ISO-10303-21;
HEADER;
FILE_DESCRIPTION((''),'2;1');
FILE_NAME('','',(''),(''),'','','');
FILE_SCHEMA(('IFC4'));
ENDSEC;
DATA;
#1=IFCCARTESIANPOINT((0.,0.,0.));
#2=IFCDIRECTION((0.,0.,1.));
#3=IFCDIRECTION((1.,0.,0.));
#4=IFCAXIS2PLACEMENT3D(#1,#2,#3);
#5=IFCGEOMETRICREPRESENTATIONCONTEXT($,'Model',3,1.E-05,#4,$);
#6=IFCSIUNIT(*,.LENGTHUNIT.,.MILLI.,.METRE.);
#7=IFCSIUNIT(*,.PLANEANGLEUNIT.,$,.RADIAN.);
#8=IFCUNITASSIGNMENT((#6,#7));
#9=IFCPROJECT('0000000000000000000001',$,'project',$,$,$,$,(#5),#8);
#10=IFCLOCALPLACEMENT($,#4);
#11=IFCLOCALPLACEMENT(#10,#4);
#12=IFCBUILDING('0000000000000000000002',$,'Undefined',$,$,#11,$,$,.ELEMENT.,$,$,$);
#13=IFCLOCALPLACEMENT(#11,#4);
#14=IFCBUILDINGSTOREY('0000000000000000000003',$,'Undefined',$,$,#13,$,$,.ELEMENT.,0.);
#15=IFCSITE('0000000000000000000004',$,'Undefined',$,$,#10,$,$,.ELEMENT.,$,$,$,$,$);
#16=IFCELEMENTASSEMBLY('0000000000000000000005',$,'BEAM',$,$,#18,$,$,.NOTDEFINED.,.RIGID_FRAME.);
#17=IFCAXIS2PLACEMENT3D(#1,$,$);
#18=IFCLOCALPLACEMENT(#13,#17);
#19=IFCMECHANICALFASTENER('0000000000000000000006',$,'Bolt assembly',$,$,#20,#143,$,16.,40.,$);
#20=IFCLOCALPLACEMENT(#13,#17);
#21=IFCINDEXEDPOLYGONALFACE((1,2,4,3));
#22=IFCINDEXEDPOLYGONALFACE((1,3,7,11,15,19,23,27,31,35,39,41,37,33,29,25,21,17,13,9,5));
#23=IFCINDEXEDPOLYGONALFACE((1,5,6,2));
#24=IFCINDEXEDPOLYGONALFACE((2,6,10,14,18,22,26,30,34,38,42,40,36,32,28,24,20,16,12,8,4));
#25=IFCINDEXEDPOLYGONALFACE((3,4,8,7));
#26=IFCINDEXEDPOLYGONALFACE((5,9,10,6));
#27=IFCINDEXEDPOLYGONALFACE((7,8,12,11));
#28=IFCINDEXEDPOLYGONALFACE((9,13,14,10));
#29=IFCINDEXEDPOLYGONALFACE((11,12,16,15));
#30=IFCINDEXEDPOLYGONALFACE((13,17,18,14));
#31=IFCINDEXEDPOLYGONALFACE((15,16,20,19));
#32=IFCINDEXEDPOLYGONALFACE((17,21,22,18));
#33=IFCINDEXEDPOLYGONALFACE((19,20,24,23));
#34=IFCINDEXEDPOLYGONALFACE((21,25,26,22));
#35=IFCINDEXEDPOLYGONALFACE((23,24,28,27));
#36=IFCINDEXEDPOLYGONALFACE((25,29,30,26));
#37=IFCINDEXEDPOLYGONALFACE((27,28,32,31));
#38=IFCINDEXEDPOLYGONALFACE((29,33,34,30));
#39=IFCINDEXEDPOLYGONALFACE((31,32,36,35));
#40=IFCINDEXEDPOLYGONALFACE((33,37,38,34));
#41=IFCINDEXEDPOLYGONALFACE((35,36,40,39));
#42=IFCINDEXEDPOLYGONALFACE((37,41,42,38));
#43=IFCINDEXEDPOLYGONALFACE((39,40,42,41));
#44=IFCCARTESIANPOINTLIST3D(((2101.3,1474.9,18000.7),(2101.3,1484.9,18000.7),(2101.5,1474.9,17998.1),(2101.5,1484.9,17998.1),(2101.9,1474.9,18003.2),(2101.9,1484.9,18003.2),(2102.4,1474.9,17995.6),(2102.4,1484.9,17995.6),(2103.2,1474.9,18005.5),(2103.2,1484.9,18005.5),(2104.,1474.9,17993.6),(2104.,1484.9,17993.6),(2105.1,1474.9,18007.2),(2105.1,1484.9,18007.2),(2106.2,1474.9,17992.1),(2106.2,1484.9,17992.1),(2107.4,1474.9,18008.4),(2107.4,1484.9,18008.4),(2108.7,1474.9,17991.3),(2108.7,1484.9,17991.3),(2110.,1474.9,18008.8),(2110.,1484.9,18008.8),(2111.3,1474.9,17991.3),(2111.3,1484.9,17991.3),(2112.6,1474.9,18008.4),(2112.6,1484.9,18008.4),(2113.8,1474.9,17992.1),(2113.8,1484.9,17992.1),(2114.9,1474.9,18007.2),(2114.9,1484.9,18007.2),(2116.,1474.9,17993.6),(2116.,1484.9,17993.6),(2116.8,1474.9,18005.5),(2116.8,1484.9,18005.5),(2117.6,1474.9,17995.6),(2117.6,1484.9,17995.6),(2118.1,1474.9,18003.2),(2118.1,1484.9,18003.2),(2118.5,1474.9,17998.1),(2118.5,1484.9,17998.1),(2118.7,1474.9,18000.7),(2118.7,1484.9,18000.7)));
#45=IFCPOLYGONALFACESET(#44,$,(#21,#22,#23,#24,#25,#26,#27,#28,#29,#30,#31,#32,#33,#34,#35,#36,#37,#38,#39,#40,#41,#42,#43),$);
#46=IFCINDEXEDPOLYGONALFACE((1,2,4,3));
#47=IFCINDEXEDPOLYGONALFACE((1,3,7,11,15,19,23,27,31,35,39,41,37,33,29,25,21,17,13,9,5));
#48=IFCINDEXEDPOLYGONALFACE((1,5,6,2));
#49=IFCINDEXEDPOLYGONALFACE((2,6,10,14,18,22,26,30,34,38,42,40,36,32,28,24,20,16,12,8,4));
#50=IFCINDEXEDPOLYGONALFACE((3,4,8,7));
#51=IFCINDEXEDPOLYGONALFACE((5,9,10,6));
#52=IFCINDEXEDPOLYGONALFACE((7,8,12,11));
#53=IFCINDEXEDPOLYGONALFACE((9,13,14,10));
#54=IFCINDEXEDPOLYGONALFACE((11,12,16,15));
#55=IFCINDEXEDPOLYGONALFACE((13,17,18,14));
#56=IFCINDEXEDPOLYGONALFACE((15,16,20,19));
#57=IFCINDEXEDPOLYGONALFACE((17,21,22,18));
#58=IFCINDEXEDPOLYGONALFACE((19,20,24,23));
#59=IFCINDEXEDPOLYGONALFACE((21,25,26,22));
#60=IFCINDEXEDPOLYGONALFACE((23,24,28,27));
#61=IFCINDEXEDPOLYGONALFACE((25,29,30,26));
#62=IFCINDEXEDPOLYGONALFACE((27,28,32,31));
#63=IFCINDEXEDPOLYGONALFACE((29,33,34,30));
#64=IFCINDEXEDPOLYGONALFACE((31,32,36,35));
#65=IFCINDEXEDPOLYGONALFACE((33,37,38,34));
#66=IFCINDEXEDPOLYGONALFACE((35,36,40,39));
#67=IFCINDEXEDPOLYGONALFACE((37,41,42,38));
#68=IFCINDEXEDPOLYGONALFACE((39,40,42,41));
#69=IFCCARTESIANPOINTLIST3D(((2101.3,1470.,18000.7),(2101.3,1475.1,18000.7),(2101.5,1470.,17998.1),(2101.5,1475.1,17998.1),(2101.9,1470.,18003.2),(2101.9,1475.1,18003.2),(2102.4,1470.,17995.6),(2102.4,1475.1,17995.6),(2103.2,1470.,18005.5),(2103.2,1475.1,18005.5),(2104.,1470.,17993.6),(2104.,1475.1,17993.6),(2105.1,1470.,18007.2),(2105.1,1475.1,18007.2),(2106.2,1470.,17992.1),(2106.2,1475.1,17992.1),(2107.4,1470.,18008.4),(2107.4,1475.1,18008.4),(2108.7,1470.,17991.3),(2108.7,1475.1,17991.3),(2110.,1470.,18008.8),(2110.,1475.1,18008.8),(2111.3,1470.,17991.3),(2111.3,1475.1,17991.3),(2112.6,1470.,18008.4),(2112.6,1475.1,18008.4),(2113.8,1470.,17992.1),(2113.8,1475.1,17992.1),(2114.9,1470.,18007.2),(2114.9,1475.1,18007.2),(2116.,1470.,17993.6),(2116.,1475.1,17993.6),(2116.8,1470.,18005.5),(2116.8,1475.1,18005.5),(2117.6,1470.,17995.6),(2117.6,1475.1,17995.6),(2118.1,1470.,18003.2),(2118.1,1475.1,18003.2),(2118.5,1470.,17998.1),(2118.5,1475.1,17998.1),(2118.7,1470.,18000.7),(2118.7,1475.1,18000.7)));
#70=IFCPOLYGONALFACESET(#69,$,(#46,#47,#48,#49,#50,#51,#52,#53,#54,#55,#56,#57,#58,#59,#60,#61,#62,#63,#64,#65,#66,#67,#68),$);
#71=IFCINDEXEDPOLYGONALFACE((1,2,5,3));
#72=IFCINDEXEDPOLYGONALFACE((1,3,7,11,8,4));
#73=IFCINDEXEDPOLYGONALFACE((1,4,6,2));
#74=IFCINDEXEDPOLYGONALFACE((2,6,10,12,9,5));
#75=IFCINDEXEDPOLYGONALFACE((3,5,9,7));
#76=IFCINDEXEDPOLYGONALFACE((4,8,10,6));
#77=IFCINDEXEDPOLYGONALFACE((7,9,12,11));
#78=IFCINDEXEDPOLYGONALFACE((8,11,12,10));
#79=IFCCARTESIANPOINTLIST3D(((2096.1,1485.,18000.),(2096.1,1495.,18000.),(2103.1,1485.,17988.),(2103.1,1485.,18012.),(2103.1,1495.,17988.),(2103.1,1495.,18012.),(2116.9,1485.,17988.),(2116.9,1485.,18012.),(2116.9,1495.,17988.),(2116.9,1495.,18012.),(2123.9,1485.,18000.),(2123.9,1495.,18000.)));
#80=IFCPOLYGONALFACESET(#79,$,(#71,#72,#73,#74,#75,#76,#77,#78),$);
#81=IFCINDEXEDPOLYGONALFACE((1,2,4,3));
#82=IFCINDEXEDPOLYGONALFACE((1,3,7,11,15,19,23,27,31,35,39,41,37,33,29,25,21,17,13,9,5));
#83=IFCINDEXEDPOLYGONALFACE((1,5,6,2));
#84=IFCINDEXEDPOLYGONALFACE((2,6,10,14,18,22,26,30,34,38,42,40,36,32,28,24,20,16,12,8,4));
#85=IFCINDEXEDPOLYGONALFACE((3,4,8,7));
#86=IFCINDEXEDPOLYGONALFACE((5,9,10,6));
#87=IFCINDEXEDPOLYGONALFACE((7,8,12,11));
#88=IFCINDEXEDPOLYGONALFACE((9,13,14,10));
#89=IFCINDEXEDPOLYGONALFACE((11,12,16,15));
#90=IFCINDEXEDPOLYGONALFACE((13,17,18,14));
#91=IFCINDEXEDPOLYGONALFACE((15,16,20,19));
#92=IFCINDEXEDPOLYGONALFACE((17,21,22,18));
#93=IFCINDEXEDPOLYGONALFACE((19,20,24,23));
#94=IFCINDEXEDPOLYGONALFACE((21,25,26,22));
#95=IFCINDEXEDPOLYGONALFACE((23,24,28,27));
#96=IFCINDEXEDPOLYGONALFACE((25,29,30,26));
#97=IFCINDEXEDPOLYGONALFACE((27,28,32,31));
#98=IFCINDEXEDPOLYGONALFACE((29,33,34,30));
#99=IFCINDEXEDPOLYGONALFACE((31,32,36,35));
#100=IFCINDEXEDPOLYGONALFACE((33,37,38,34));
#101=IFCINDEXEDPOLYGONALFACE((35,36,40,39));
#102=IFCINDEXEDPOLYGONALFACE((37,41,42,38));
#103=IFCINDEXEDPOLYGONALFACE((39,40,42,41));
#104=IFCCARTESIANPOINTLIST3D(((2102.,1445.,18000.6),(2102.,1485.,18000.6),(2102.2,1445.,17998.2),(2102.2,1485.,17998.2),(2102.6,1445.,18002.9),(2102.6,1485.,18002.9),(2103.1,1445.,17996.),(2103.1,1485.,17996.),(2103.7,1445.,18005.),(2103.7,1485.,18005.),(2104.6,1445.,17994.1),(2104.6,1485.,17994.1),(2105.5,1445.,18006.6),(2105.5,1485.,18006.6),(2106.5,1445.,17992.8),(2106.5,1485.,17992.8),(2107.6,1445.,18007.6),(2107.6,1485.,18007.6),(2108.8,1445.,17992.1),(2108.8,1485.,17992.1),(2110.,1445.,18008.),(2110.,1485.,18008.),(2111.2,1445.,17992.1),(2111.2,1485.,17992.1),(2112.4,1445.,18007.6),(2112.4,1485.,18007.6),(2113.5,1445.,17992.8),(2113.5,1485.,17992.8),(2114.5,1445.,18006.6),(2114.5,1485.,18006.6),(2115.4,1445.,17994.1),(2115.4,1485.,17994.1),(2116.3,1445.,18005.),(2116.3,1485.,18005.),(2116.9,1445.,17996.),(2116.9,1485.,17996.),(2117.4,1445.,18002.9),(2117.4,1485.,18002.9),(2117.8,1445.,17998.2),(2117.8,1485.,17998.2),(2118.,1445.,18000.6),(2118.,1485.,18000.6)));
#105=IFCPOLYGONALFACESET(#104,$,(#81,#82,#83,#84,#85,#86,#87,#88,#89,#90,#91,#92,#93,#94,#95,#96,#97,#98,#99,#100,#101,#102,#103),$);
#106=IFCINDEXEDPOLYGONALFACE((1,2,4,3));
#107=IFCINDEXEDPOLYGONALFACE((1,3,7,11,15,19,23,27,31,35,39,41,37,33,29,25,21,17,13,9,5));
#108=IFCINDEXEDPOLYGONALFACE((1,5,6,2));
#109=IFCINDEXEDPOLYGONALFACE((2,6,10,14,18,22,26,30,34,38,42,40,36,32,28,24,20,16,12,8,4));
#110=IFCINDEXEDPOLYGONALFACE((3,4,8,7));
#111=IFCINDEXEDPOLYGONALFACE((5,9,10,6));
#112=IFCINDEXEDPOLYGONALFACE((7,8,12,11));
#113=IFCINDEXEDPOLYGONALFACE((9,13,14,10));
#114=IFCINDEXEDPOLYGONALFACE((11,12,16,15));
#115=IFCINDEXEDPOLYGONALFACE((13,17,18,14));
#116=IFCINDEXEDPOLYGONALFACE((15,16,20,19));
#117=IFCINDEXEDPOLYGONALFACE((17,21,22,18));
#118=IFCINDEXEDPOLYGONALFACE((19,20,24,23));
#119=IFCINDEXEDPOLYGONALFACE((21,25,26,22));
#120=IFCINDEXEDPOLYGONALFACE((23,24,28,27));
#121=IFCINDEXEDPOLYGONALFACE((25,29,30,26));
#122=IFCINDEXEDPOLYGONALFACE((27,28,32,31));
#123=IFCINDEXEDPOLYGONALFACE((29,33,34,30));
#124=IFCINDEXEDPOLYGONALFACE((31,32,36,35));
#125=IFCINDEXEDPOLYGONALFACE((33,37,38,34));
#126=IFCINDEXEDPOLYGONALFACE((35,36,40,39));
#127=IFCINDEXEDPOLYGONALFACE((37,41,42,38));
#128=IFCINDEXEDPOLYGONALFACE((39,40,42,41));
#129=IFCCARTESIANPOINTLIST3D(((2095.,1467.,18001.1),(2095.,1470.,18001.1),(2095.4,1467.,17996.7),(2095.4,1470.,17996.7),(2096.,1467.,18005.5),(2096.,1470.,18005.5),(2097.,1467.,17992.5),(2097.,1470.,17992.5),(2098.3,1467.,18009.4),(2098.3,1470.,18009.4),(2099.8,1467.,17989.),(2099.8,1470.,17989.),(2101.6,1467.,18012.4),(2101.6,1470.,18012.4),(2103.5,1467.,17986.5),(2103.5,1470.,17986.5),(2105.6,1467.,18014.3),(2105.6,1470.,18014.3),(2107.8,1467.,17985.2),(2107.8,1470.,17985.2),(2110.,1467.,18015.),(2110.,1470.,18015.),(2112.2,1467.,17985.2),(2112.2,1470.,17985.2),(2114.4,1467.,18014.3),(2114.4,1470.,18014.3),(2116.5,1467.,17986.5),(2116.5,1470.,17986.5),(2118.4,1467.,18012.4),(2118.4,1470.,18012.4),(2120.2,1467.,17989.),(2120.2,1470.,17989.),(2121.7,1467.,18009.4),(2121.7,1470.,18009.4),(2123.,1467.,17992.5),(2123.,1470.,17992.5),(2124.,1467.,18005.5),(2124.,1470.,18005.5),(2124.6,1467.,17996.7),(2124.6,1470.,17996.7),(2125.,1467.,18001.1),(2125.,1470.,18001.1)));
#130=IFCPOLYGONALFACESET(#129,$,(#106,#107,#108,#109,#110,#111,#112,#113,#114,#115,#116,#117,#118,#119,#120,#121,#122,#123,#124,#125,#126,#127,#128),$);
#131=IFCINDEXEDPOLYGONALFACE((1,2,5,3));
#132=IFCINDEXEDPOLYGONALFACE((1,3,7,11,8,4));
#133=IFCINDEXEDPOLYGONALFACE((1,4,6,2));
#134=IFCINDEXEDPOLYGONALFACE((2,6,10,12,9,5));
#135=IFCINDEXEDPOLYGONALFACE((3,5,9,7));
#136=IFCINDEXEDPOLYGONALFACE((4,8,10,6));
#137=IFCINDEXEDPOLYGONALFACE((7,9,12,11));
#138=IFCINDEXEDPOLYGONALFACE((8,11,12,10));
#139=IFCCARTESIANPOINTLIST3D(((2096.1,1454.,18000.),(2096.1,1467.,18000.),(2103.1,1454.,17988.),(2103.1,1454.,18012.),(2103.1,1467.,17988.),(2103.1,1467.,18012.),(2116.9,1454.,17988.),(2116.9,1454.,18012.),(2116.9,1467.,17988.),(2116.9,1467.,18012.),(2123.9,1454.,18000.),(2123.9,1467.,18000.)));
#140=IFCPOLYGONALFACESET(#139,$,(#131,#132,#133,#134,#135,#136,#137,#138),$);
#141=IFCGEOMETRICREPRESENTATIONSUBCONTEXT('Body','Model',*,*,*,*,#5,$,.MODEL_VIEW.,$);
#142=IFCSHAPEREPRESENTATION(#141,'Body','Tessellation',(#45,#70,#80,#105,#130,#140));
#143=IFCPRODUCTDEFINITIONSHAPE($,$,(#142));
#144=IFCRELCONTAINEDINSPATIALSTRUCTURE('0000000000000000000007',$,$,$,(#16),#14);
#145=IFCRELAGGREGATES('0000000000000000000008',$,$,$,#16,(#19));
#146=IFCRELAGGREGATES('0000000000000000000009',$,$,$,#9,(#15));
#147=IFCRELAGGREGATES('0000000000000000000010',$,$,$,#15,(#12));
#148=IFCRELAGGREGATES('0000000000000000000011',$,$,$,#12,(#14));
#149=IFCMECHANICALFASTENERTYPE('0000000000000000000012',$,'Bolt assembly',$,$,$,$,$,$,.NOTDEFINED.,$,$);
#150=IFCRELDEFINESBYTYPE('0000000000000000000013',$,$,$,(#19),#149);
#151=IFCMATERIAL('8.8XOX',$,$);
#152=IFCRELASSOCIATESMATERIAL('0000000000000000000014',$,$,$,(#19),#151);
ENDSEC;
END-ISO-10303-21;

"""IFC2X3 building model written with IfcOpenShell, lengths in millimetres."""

from ifc_helpers import new_model, si_unit, frame, origin_with_axes, origin_2d_with_axis, place, context, subcontext, project, spatial, polyline, circle, outline, extrude, source, transform, mapped, material, type_object, element, aggregate, save


model = new_model("IFC2X3")

# Units and contexts
model_context = context("Model", 3, precision=1e-05, world=origin_with_axes())
body_context = subcontext(model_context, "Body", "Model", "MODEL_VIEW")
ifc_project = project(units=[si_unit("LENGTHUNIT", "METRE", prefix="MILLI"), si_unit("PLANEANGLEUNIT", "RADIAN")], contexts=[model_context])

# Site, building, storey
site_placement = place(None, origin_with_axes())
site = spatial("IfcSite", under=ifc_project, at=site_placement, Name="Undefined", CompositionType="ELEMENT")
building_placement = place(site_placement, origin_with_axes())
building = spatial("IfcBuilding", under=site, at=building_placement, Name="Undefined", CompositionType="ELEMENT")
storey_placement = place(building_placement, origin_with_axes())
storey = spatial("IfcBuildingStorey", under=building, at=storey_placement, Name="Undefined", CompositionType="ELEMENT", Elevation=0.0)

# Element assembly
assembly_1_placement = place(storey_placement, origin_with_axes())
assembly_1 = element("IfcElementAssembly", 1, at=assembly_1_placement, inside=storey, Name="BEAM", AssemblyPlace="NOTDEFINED", PredefinedType="RIGID_FRAME")

# Mechanical fastener
ifc_material_1 = material(Name="8.8XOX")
mechanical_fastener_type = type_object("IfcMechanicalFastenerType", Name="Bolt assembly")
shared_shape_1 = source(origin_with_axes(), body_context, "Body", "SweptSolid", [
    extrude(circle(Radius=8.8, at=origin_2d_with_axis()), frame((0.0, 15.1, 0.0), z_axis=(0.0, 1.0, 0.0), x_axis=(1.0, 0.0, 0.0)), (0.0, 0.0, 1.0), 10.0),
    extrude(circle(Radius=8.8, at=origin_2d_with_axis()), frame((0.0, 24.9, 0.0), z_axis=(0.0, 1.0, 0.0), x_axis=(1.0, 0.0, 0.0)), (0.0, 0.0, 1.0), 5.1),
    extrude(outline(polyline([(12.0, -6.9), (12.0, 6.9), (0.0, 13.9), (-12.0, 6.9), (-12.0, -6.9), (0.0, -13.9), (12.0, -6.9)])), frame((0.0, 5.0, 0.0), z_axis=(0.0, 1.0, 0.0), x_axis=(1.0, 0.0, 0.0)), (0.0, 0.0, 1.0), 10.0),
    extrude(circle(Radius=8.0, at=origin_2d_with_axis()), frame((0.0, 15.0, 0.0), z_axis=(0.0, 1.0, 0.0), x_axis=(1.0, 0.0, 0.0)), (0.0, 0.0, 1.0), 40.0),
    extrude(circle(Radius=15.0, at=origin_2d_with_axis()), frame((0.0, 30.0, 0.0), z_axis=(0.0, 1.0, 0.0), x_axis=(1.0, 0.0, 0.0)), (0.0, 0.0, 1.0), 3.0),
    extrude(outline(polyline([(12.0, -6.9), (12.0, 6.9), (0.0, 13.9), (-12.0, 6.9), (-12.0, -6.9), (0.0, -13.9), (12.0, -6.9)])), frame((0.0, 33.0, 0.0), z_axis=(0.0, 1.0, 0.0), x_axis=(1.0, 0.0, 0.0)), (0.0, 0.0, 1.0), 13.0),
])
mechanical_fastener_1_placement = place(assembly_1_placement, frame((2110.0, 1500.0, 18000.0), z_axis=(1.0, 0.0, 0.0), x_axis=(0.0, 0.0, 1.0)))
mechanical_fastener_1 = element("IfcMechanicalFastener", 2, at=mechanical_fastener_1_placement, type_object=mechanical_fastener_type, material=ifc_material_1, Name="Bolt assembly", NominalDiameter=16.0, NominalLength=40.0, context=body_context, shape_type="MappedRepresentation", body=[
    mapped(shared_shape_1, transform((0.0, 0.0, 0.0))),
])
aggregate(assembly_1, [mechanical_fastener_1])

save(model, "model.ifc")
